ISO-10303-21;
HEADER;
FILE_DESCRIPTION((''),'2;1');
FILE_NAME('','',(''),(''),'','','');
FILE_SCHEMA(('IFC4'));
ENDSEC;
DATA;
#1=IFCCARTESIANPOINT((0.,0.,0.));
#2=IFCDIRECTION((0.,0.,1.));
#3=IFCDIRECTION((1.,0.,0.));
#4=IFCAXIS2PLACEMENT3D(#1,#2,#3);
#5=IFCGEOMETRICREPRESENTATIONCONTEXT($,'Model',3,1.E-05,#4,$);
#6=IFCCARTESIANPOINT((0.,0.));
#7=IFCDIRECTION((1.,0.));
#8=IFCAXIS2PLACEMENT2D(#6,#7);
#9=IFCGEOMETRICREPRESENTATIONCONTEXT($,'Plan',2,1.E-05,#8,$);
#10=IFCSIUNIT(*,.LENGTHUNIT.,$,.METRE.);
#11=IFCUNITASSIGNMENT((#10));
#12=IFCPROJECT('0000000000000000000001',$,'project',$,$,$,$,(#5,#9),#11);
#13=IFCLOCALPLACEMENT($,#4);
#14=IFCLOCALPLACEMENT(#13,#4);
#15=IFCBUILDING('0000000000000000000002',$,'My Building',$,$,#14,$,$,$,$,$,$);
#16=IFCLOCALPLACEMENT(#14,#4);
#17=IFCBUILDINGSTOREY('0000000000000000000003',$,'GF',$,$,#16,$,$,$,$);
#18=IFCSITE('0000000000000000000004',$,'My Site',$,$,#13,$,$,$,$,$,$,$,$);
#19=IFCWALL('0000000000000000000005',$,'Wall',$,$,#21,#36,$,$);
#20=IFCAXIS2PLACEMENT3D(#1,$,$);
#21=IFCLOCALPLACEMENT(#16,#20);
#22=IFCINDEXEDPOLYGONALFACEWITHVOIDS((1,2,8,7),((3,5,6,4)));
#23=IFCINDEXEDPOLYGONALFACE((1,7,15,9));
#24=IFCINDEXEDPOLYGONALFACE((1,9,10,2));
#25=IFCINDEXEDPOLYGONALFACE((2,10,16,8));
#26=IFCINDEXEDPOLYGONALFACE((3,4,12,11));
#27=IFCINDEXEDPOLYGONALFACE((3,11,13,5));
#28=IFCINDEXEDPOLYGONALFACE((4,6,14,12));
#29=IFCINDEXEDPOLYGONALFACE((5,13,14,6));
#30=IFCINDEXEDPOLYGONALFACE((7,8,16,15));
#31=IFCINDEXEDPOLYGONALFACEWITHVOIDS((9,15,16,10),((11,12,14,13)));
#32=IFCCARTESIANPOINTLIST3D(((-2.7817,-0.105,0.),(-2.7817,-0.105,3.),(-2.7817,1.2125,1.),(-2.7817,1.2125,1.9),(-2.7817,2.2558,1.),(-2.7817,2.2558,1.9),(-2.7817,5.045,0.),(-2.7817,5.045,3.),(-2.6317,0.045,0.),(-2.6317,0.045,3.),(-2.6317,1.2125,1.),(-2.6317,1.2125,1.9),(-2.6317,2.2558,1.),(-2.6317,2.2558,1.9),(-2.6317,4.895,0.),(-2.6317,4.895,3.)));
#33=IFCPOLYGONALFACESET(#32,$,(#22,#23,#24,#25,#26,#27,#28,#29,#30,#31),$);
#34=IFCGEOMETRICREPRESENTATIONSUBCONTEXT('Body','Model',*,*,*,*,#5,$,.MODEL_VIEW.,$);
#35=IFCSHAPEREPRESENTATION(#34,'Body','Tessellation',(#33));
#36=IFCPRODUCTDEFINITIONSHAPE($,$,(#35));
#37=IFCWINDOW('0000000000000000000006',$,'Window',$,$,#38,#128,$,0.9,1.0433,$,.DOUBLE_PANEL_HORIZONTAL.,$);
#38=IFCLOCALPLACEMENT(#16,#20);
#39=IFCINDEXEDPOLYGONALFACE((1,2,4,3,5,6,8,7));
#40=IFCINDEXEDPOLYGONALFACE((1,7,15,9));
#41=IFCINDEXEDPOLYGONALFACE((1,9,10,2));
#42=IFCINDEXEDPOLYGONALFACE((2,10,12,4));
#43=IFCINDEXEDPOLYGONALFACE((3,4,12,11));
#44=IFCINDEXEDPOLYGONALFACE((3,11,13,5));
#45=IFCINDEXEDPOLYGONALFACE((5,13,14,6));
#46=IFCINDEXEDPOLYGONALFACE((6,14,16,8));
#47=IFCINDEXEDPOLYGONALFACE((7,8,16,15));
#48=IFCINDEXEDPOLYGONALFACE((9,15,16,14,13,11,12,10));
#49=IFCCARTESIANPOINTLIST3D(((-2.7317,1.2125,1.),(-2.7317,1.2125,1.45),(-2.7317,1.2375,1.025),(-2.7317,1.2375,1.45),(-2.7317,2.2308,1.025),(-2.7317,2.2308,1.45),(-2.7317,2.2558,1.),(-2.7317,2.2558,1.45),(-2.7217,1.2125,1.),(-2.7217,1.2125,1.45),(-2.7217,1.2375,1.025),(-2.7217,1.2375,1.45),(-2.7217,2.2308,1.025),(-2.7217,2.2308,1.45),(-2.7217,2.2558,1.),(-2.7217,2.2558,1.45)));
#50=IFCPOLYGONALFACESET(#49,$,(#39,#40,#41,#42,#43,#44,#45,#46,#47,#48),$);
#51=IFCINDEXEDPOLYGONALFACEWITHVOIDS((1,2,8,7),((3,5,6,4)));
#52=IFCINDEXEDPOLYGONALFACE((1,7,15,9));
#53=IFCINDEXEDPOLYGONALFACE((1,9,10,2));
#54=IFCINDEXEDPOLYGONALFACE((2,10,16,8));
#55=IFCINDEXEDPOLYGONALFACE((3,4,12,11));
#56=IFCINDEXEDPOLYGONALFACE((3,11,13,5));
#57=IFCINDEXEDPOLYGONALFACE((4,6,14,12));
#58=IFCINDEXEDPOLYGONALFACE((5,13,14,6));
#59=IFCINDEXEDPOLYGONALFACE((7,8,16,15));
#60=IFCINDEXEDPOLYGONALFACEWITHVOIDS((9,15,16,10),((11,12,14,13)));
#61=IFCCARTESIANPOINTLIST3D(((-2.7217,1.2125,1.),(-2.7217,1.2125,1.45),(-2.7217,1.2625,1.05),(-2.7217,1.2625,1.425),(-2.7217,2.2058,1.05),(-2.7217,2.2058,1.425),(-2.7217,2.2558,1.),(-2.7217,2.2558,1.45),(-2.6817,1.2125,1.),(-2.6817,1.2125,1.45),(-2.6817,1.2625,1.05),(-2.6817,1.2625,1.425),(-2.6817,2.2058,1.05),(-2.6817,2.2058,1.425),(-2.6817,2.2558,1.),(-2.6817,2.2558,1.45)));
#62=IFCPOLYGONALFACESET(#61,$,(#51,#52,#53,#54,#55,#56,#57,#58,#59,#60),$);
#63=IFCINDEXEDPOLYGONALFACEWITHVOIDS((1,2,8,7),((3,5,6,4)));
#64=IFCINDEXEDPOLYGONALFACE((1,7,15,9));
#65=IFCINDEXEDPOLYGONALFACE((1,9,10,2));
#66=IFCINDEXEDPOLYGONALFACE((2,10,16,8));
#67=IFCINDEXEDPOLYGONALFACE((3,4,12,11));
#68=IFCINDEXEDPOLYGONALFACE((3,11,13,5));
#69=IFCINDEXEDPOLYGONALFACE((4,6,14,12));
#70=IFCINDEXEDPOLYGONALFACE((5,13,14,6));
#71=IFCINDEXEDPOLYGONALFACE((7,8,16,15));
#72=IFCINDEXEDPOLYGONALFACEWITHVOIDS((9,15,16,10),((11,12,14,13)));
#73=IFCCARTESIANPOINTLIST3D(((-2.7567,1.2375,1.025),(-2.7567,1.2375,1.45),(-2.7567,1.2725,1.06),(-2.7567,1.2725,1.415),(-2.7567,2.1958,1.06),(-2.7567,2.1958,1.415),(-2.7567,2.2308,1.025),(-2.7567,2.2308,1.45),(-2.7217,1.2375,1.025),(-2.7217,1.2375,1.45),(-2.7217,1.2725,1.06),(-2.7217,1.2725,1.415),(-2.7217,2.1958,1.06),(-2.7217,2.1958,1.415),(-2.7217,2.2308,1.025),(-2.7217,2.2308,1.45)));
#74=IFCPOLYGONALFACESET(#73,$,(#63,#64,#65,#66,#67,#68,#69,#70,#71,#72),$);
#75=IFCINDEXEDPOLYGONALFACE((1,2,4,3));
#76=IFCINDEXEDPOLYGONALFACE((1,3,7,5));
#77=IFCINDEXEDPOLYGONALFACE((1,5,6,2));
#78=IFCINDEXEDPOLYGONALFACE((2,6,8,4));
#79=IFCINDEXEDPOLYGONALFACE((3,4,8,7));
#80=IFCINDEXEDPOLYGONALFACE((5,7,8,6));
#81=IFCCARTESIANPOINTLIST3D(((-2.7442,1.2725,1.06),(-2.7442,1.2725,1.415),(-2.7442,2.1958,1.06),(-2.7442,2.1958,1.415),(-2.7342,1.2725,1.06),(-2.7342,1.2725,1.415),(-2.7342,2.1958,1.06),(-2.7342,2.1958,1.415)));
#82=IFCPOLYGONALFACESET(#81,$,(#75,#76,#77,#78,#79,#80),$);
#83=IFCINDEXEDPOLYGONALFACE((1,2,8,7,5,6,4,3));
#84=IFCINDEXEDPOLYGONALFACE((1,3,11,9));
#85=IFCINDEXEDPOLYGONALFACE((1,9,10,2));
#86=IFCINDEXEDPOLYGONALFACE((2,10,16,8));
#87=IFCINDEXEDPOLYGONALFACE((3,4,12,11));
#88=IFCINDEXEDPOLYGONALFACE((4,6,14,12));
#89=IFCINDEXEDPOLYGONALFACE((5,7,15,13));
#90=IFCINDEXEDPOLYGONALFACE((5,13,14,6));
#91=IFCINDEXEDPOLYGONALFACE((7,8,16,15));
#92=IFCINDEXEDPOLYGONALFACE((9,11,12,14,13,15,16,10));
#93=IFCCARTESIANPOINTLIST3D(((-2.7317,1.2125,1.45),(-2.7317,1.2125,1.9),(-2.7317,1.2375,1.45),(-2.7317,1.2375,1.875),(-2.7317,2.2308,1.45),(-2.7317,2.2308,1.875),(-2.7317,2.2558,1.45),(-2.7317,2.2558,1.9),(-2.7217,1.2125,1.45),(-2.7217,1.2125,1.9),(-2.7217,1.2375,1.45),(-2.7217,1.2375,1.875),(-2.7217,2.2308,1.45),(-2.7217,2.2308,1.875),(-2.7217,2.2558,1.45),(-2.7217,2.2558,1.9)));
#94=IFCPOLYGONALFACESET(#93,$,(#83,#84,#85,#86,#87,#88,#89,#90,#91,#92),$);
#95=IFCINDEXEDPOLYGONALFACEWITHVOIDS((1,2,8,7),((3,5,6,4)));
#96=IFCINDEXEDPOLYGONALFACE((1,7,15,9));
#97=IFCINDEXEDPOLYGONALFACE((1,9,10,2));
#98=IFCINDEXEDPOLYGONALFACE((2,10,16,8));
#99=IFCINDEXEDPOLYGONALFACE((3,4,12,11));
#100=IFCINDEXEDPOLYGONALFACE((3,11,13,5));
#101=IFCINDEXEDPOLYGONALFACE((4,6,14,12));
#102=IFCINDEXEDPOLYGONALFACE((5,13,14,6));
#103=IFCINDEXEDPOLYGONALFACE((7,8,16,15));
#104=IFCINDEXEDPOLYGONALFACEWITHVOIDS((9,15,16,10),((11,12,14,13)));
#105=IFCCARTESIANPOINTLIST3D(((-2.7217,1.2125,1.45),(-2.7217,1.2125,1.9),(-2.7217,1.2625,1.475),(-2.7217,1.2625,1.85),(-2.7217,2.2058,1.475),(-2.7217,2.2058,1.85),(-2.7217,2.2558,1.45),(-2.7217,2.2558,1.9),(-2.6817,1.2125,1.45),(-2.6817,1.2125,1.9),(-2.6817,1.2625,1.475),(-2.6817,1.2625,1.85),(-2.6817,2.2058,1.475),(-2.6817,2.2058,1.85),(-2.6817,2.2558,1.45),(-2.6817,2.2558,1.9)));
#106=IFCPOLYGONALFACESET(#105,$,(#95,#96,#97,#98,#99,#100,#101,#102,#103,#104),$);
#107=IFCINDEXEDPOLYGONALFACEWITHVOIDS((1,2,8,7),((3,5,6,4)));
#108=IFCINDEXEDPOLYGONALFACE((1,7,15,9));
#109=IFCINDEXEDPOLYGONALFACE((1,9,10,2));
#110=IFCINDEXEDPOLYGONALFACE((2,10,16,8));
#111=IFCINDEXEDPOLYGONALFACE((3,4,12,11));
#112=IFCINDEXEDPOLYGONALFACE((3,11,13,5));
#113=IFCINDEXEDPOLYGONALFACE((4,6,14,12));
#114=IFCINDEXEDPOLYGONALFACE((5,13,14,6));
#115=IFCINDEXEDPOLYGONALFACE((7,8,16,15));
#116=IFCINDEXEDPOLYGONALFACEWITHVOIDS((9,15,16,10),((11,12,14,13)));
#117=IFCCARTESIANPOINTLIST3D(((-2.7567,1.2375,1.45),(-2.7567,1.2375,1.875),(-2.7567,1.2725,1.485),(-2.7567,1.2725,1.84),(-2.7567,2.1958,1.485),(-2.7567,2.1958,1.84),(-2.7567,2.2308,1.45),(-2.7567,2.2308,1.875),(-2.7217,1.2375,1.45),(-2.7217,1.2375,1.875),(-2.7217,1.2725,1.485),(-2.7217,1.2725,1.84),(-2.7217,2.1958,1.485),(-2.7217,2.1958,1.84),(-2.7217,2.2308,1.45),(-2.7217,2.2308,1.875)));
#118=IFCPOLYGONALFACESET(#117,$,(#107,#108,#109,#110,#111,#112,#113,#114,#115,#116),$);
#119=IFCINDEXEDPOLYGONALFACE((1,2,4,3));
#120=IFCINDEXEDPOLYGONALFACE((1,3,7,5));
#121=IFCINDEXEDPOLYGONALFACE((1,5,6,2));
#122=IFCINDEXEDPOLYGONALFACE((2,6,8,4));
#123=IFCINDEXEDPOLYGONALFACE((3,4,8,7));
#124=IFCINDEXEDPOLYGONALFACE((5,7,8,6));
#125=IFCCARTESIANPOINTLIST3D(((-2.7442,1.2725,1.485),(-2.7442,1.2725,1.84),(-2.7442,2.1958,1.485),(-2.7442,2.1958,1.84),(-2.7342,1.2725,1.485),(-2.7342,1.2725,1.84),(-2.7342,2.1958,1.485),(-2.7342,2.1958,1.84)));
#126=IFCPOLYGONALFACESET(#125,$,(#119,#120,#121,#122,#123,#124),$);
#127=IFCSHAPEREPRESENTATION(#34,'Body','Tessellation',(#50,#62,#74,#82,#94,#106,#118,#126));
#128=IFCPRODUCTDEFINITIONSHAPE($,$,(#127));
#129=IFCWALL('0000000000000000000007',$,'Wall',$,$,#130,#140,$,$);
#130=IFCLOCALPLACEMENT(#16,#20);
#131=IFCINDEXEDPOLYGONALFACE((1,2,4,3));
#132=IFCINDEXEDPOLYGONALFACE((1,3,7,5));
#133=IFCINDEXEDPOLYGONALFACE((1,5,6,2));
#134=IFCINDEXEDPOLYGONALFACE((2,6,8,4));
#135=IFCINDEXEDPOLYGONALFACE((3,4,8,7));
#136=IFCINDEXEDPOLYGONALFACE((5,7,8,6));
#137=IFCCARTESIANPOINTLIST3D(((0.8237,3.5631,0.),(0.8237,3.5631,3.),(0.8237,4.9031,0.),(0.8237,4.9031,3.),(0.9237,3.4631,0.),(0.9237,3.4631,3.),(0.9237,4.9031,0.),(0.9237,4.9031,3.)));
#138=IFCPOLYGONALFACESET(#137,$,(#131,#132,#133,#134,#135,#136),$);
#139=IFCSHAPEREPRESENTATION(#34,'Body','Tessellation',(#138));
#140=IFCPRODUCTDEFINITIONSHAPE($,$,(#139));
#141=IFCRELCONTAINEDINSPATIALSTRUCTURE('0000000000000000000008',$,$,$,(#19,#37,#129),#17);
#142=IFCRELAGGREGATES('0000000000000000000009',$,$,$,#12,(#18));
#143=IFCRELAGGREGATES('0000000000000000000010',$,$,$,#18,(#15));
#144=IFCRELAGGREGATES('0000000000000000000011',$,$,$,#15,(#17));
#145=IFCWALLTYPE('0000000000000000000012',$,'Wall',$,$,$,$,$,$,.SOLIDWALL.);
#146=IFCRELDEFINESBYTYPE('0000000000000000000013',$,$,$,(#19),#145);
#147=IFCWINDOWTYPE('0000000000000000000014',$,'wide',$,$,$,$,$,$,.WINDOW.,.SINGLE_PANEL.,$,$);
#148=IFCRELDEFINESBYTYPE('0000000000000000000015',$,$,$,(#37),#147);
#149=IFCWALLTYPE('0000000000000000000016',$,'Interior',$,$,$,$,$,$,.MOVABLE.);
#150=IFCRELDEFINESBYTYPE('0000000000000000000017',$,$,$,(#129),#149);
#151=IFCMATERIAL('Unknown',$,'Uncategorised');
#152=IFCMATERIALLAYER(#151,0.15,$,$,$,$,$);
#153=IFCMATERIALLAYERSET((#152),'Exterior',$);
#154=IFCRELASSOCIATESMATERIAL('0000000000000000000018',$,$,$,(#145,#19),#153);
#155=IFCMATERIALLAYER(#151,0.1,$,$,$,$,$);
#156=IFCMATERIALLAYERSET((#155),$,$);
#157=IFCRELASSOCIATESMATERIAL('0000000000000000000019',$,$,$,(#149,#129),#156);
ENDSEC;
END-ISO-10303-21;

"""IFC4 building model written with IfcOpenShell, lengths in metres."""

from ifc_helpers import new_model, entity, si_unit, frame, origin_with_axes, origin_2d_with_axis, place, context, subcontext, project, spatial, line, indexed_curve, outline, extrude, shape, source, transform, mapped, material, layer, layer_set, layer_usage, type_object, type_shapes, element, fill, save


model = new_model("IFC4")

# Units and contexts
model_context = context("Model", 3, precision=1e-05, world=origin_with_axes())
plan_context = context("Plan", 2, precision=1e-05, world=origin_2d_with_axis())
body_context_1 = subcontext(model_context, "Body", "Model", "MODEL_VIEW")
body_context_2 = subcontext(plan_context, "Body", "Plan", "PLAN_VIEW")
ifc_project = project(units=[si_unit("LENGTHUNIT", "METRE")], contexts=[model_context, plan_context])

# Site, building, storey
site_placement = place(None, origin_with_axes())
site = spatial("IfcSite", under=ifc_project, at=site_placement, Name="My Site")
building_placement = place(site_placement, origin_with_axes())
building = spatial("IfcBuilding", under=site, at=building_placement, Name="My Building")
storey_placement = place(building_placement, origin_with_axes())
storey = spatial("IfcBuildingStorey", under=building, at=storey_placement, Name="GF")

# Shared definitions
ifc_material = material(Name="Unknown", Category="Uncategorised")

# Shared definitions
ifc_layer_1 = layer(ifc_material, 0.15)
ifc_layer_set_1 = layer_set([ifc_layer_1], Name="Exterior")
wall_type_1 = type_object("IfcWallType", Name="Wall", PredefinedType="SOLIDWALL", material=ifc_layer_set_1)

# Shared definitions
shared_shape_1 = source(origin_with_axes(), body_context_1, "Body", "SweptSolid", [
    extrude(outline(indexed_curve([(0.0, 0.0), (1.0433, 0.0), (1.0433, 0.9), (0.0, 0.9)], segments=[line(1, 2, 3, 4, 1)])), frame((0.0, -0.6, 0.0), z_axis=(0.0, -1.0, 0.0), x_axis=(1.0, 0.0, 0.0)), (0.0, 0.0, -1.0), 1.2),
])
window_type_1 = type_object("IfcWindowType", Name="wide", PartitioningType="SINGLE_PANEL", PredefinedType="WINDOW")
shared_shape_2 = source(origin_with_axes(), body_context_1, "Body", "SweptSolid", [
    extrude(outline(indexed_curve([(1.0433, 0.45), (1.0433, 0.0), (0.0, 0.0), (0.0, 0.45), (0.025, 0.45), (0.025, 0.025), (1.0183, 0.025), (1.0183, 0.45)], segments=[line(1, 2, 3, 4, 5, 6, 7, 8, 1)])), frame((0.0, 0.09, 0.0), z_axis=(0.0, -1.0, 0.0), x_axis=(1.0, 0.0, 0.0)), (0.0, 0.0, -1.0), 0.01),
    extrude(outline(indexed_curve([(0.0, 0.0), (1.0433, 0.0), (1.0433, 0.45), (0.0, 0.45)], segments=[line(1, 2, 3, 4, 1)]), holes=[indexed_curve([(0.05, 0.05), (0.9933, 0.05), (0.9933, 0.425), (0.05, 0.425)], segments=[line(1, 2, 3, 4, 1)])]), frame((0.0, 0.05, 0.0), z_axis=(0.0, -1.0, 0.0), x_axis=(1.0, 0.0, 0.0)), (0.0, 0.0, -1.0), 0.04),
    extrude(outline(indexed_curve([(0.0, 0.0), (0.9933, 0.0), (0.9933, 0.425), (0.0, 0.425)], segments=[line(1, 2, 3, 4, 1)]), holes=[indexed_curve([(0.035, 0.035), (0.9583, 0.035), (0.9583, 0.39), (0.035, 0.39)], segments=[line(1, 2, 3, 4, 1)])]), frame((0.025, 0.09, 0.025), z_axis=(0.0, -1.0, 0.0), x_axis=(1.0, 0.0, 0.0)), (0.0, 0.0, -1.0), 0.035),
    extrude(outline(indexed_curve([(0.035, 0.035), (0.9583, 0.035), (0.9583, 0.39), (0.035, 0.39)], segments=[line(1, 2, 3, 4, 1)])), frame((0.025, 0.1025, 0.025), z_axis=(0.0, -1.0, 0.0), x_axis=(1.0, 0.0, 0.0)), (0.0, 0.0, -1.0), 0.01),
    extrude(outline(indexed_curve([(0.0, 0.0), (0.0, 0.45), (1.0433, 0.45), (1.0433, 0.0), (1.0183, 0.0), (1.0183, 0.425), (0.025, 0.425), (0.025, 0.0)], segments=[line(1, 2, 3, 4, 5, 6, 7, 8, 1)])), frame((0.0, 0.09, 0.45), z_axis=(0.0, -1.0, 0.0), x_axis=(1.0, 0.0, 0.0)), (0.0, 0.0, -1.0), 0.01),
    extrude(outline(indexed_curve([(0.0, 0.0), (1.0433, 0.0), (1.0433, 0.45), (0.0, 0.45)], segments=[line(1, 2, 3, 4, 1)]), holes=[indexed_curve([(0.05, 0.025), (0.9933, 0.025), (0.9933, 0.4), (0.05, 0.4)], segments=[line(1, 2, 3, 4, 1)])]), frame((0.0, 0.05, 0.45), z_axis=(0.0, -1.0, 0.0), x_axis=(1.0, 0.0, 0.0)), (0.0, 0.0, -1.0), 0.04),
    extrude(outline(indexed_curve([(0.0, 0.0), (0.9933, 0.0), (0.9933, 0.425), (0.0, 0.425)], segments=[line(1, 2, 3, 4, 1)]), holes=[indexed_curve([(0.035, 0.035), (0.9583, 0.035), (0.9583, 0.39), (0.035, 0.39)], segments=[line(1, 2, 3, 4, 1)])]), frame((0.025, 0.09, 0.45), z_axis=(0.0, -1.0, 0.0), x_axis=(1.0, 0.0, 0.0)), (0.0, 0.0, -1.0), 0.035),
    extrude(outline(indexed_curve([(0.035, 0.035), (0.9583, 0.035), (0.9583, 0.39), (0.035, 0.39)], segments=[line(1, 2, 3, 4, 1)])), frame((0.025, 0.1025, 0.45), z_axis=(0.0, -1.0, 0.0), x_axis=(1.0, 0.0, 0.0)), (0.0, 0.0, -1.0), 0.01),
])
shared_shape_3 = source(origin_with_axes(), body_context_2, "Body", "Curve2D", [
    entity("IfcIndexedPolyCurve", entity("IfcCartesianPointList2D", [[0.05, 0.05], [0.9933, 0.05]])),
    entity("IfcIndexedPolyCurve", entity("IfcCartesianPointList2D", [[0.0, 0.1], [0.025, 0.1], [0.025, 0.09], [0.05, 0.09], [0.05, 0.05], [0.0, 0.05]]), [entity("IfcLineIndex", [1, 2, 3, 4, 5, 6, 1])]),
    entity("IfcIndexedPolyCurve", entity("IfcCartesianPointList2D", [[1.0433, 0.1], [1.0183, 0.1], [1.0183, 0.09], [0.9933, 0.09], [0.9933, 0.05], [1.0433, 0.05]]), [entity("IfcLineIndex", [1, 2, 3, 4, 5, 6, 1])]),
    entity("IfcIndexedPolyCurve", entity("IfcCartesianPointList2D", [[0.025, 0.09], [0.06, 0.09], [0.06, 0.125], [0.025, 0.125]]), [entity("IfcLineIndex", [1, 2, 3, 4, 1])]),
    entity("IfcIndexedPolyCurve", entity("IfcCartesianPointList2D", [[1.0183, 0.09], [0.9833, 0.09], [0.9833, 0.125], [1.0183, 0.125]]), [entity("IfcLineIndex", [1, 2, 3, 4, 1])]),
    entity("IfcIndexedPolyCurve", entity("IfcCartesianPointList2D", [[0.06, 0.09], [0.9833, 0.09]])),
    entity("IfcIndexedPolyCurve", entity("IfcCartesianPointList2D", [[0.06, 0.125], [0.9833, 0.125]])),
    entity("IfcIndexedPolyCurve", entity("IfcCartesianPointList2D", [[0.06, 0.1075], [0.9833, 0.1075]])),
])
type_shapes(window_type_1, [shared_shape_2, shared_shape_3])

# Wall, opening, window
ifc_layer_usage_1 = layer_usage(ifc_layer_set_1, "AXIS2", "POSITIVE", 0.0)
wall_1_placement = place(storey_placement, frame((-2.7817, 5.045, 0.0), z_axis=(0.0, 0.0, 1.0), x_axis=(0.0, -1.0, 0.0)))
wall_1 = element("IfcWall", 1, at=wall_1_placement, inside=storey, type_object=wall_type_1, material=ifc_layer_usage_1, Name="Wall", context=body_context_1, shape_type="SweptSolid", body=[
    extrude(outline(indexed_curve([(0.0, 0.0), (0.15, 0.15), (5.0, 0.15), (5.15, 0.0)], segments=[line(1, 2, 3, 4, 1)])), origin_with_axes(), (0.0, 0.0, 1.0), 3.0),
])
opening_1_placement = place(wall_1_placement, frame((3.8324, 0.15, 1.0), z_axis=(0.0, 0.0, 1.0), x_axis=(-1.0, 0.0, 0.0)))
opening_1 = element("IfcOpeningElement", 2, at=opening_1_placement, cuts=wall_1, PredefinedType="OPENING", context=body_context_1, shape_type="MappedRepresentation", body=[
    mapped(shared_shape_1, transform((0.0, 0.0, 0.0), x_axis=(1.0, 0.0, 0.0), y_axis=(0.0, 1.0, 0.0), z_axis=(0.0, 0.0, 1.0), scale=1.0)),
])
window_1_placement = place(opening_1_placement, frame((0.0, 0.0, 0.0), z_axis=(0.0, 0.0, 1.0), x_axis=(1.0, 0.0, 0.0)))
window_1 = element("IfcWindow", 3, at=window_1_placement, inside=storey, type_object=window_type_1, Name="Window", OverallHeight=0.9, OverallWidth=1.0433, PartitioningType="DOUBLE_PANEL_HORIZONTAL", shapes=[
    shape(body_context_1, "Body", "MappedRepresentation", [mapped(shared_shape_2, transform((0.0, 0.0, 0.0), x_axis=(1.0, 0.0, 0.0), y_axis=(0.0, 1.0, 0.0), z_axis=(0.0, 0.0, 1.0), scale=1.0))]),
    shape(body_context_2, "Body", "MappedRepresentation", [mapped(shared_shape_3, transform((0.0, 0.0, 0.0), x_axis=(1.0, 0.0, 0.0), y_axis=(0.0, 1.0, 0.0), z_axis=(0.0, 0.0, 1.0), scale=1.0))]),
])
fill(opening_1, window_1)

# Wall
ifc_layer_2 = layer(ifc_material, 0.1)
ifc_layer_set_2 = layer_set([ifc_layer_2])
ifc_layer_usage_2 = layer_usage(ifc_layer_set_2, "AXIS2", "POSITIVE", 0.0)
wall_type_2 = type_object("IfcWallType", Name="Interior", PredefinedType="MOVABLE", material=ifc_layer_set_2)
wall_2_placement = place(storey_placement, frame((0.8237, 4.9031, 0.0), z_axis=(0.0, 0.0, 1.0), x_axis=(0.0, -1.0, 0.0)))
element("IfcWall", 4, at=wall_2_placement, inside=storey, type_object=wall_type_2, material=ifc_layer_usage_2, Name="Wall", context=body_context_1, shape_type="SweptSolid", body=[
    extrude(outline(indexed_curve([(0.0, 0.0), (0.0, 0.1), (1.44, 0.1), (1.34, 0.0)], segments=[line(1, 2, 3, 4, 1)])), origin_with_axes(), (0.0, 0.0, 1.0), 3.0),
])

save(model, "model.ifc")
